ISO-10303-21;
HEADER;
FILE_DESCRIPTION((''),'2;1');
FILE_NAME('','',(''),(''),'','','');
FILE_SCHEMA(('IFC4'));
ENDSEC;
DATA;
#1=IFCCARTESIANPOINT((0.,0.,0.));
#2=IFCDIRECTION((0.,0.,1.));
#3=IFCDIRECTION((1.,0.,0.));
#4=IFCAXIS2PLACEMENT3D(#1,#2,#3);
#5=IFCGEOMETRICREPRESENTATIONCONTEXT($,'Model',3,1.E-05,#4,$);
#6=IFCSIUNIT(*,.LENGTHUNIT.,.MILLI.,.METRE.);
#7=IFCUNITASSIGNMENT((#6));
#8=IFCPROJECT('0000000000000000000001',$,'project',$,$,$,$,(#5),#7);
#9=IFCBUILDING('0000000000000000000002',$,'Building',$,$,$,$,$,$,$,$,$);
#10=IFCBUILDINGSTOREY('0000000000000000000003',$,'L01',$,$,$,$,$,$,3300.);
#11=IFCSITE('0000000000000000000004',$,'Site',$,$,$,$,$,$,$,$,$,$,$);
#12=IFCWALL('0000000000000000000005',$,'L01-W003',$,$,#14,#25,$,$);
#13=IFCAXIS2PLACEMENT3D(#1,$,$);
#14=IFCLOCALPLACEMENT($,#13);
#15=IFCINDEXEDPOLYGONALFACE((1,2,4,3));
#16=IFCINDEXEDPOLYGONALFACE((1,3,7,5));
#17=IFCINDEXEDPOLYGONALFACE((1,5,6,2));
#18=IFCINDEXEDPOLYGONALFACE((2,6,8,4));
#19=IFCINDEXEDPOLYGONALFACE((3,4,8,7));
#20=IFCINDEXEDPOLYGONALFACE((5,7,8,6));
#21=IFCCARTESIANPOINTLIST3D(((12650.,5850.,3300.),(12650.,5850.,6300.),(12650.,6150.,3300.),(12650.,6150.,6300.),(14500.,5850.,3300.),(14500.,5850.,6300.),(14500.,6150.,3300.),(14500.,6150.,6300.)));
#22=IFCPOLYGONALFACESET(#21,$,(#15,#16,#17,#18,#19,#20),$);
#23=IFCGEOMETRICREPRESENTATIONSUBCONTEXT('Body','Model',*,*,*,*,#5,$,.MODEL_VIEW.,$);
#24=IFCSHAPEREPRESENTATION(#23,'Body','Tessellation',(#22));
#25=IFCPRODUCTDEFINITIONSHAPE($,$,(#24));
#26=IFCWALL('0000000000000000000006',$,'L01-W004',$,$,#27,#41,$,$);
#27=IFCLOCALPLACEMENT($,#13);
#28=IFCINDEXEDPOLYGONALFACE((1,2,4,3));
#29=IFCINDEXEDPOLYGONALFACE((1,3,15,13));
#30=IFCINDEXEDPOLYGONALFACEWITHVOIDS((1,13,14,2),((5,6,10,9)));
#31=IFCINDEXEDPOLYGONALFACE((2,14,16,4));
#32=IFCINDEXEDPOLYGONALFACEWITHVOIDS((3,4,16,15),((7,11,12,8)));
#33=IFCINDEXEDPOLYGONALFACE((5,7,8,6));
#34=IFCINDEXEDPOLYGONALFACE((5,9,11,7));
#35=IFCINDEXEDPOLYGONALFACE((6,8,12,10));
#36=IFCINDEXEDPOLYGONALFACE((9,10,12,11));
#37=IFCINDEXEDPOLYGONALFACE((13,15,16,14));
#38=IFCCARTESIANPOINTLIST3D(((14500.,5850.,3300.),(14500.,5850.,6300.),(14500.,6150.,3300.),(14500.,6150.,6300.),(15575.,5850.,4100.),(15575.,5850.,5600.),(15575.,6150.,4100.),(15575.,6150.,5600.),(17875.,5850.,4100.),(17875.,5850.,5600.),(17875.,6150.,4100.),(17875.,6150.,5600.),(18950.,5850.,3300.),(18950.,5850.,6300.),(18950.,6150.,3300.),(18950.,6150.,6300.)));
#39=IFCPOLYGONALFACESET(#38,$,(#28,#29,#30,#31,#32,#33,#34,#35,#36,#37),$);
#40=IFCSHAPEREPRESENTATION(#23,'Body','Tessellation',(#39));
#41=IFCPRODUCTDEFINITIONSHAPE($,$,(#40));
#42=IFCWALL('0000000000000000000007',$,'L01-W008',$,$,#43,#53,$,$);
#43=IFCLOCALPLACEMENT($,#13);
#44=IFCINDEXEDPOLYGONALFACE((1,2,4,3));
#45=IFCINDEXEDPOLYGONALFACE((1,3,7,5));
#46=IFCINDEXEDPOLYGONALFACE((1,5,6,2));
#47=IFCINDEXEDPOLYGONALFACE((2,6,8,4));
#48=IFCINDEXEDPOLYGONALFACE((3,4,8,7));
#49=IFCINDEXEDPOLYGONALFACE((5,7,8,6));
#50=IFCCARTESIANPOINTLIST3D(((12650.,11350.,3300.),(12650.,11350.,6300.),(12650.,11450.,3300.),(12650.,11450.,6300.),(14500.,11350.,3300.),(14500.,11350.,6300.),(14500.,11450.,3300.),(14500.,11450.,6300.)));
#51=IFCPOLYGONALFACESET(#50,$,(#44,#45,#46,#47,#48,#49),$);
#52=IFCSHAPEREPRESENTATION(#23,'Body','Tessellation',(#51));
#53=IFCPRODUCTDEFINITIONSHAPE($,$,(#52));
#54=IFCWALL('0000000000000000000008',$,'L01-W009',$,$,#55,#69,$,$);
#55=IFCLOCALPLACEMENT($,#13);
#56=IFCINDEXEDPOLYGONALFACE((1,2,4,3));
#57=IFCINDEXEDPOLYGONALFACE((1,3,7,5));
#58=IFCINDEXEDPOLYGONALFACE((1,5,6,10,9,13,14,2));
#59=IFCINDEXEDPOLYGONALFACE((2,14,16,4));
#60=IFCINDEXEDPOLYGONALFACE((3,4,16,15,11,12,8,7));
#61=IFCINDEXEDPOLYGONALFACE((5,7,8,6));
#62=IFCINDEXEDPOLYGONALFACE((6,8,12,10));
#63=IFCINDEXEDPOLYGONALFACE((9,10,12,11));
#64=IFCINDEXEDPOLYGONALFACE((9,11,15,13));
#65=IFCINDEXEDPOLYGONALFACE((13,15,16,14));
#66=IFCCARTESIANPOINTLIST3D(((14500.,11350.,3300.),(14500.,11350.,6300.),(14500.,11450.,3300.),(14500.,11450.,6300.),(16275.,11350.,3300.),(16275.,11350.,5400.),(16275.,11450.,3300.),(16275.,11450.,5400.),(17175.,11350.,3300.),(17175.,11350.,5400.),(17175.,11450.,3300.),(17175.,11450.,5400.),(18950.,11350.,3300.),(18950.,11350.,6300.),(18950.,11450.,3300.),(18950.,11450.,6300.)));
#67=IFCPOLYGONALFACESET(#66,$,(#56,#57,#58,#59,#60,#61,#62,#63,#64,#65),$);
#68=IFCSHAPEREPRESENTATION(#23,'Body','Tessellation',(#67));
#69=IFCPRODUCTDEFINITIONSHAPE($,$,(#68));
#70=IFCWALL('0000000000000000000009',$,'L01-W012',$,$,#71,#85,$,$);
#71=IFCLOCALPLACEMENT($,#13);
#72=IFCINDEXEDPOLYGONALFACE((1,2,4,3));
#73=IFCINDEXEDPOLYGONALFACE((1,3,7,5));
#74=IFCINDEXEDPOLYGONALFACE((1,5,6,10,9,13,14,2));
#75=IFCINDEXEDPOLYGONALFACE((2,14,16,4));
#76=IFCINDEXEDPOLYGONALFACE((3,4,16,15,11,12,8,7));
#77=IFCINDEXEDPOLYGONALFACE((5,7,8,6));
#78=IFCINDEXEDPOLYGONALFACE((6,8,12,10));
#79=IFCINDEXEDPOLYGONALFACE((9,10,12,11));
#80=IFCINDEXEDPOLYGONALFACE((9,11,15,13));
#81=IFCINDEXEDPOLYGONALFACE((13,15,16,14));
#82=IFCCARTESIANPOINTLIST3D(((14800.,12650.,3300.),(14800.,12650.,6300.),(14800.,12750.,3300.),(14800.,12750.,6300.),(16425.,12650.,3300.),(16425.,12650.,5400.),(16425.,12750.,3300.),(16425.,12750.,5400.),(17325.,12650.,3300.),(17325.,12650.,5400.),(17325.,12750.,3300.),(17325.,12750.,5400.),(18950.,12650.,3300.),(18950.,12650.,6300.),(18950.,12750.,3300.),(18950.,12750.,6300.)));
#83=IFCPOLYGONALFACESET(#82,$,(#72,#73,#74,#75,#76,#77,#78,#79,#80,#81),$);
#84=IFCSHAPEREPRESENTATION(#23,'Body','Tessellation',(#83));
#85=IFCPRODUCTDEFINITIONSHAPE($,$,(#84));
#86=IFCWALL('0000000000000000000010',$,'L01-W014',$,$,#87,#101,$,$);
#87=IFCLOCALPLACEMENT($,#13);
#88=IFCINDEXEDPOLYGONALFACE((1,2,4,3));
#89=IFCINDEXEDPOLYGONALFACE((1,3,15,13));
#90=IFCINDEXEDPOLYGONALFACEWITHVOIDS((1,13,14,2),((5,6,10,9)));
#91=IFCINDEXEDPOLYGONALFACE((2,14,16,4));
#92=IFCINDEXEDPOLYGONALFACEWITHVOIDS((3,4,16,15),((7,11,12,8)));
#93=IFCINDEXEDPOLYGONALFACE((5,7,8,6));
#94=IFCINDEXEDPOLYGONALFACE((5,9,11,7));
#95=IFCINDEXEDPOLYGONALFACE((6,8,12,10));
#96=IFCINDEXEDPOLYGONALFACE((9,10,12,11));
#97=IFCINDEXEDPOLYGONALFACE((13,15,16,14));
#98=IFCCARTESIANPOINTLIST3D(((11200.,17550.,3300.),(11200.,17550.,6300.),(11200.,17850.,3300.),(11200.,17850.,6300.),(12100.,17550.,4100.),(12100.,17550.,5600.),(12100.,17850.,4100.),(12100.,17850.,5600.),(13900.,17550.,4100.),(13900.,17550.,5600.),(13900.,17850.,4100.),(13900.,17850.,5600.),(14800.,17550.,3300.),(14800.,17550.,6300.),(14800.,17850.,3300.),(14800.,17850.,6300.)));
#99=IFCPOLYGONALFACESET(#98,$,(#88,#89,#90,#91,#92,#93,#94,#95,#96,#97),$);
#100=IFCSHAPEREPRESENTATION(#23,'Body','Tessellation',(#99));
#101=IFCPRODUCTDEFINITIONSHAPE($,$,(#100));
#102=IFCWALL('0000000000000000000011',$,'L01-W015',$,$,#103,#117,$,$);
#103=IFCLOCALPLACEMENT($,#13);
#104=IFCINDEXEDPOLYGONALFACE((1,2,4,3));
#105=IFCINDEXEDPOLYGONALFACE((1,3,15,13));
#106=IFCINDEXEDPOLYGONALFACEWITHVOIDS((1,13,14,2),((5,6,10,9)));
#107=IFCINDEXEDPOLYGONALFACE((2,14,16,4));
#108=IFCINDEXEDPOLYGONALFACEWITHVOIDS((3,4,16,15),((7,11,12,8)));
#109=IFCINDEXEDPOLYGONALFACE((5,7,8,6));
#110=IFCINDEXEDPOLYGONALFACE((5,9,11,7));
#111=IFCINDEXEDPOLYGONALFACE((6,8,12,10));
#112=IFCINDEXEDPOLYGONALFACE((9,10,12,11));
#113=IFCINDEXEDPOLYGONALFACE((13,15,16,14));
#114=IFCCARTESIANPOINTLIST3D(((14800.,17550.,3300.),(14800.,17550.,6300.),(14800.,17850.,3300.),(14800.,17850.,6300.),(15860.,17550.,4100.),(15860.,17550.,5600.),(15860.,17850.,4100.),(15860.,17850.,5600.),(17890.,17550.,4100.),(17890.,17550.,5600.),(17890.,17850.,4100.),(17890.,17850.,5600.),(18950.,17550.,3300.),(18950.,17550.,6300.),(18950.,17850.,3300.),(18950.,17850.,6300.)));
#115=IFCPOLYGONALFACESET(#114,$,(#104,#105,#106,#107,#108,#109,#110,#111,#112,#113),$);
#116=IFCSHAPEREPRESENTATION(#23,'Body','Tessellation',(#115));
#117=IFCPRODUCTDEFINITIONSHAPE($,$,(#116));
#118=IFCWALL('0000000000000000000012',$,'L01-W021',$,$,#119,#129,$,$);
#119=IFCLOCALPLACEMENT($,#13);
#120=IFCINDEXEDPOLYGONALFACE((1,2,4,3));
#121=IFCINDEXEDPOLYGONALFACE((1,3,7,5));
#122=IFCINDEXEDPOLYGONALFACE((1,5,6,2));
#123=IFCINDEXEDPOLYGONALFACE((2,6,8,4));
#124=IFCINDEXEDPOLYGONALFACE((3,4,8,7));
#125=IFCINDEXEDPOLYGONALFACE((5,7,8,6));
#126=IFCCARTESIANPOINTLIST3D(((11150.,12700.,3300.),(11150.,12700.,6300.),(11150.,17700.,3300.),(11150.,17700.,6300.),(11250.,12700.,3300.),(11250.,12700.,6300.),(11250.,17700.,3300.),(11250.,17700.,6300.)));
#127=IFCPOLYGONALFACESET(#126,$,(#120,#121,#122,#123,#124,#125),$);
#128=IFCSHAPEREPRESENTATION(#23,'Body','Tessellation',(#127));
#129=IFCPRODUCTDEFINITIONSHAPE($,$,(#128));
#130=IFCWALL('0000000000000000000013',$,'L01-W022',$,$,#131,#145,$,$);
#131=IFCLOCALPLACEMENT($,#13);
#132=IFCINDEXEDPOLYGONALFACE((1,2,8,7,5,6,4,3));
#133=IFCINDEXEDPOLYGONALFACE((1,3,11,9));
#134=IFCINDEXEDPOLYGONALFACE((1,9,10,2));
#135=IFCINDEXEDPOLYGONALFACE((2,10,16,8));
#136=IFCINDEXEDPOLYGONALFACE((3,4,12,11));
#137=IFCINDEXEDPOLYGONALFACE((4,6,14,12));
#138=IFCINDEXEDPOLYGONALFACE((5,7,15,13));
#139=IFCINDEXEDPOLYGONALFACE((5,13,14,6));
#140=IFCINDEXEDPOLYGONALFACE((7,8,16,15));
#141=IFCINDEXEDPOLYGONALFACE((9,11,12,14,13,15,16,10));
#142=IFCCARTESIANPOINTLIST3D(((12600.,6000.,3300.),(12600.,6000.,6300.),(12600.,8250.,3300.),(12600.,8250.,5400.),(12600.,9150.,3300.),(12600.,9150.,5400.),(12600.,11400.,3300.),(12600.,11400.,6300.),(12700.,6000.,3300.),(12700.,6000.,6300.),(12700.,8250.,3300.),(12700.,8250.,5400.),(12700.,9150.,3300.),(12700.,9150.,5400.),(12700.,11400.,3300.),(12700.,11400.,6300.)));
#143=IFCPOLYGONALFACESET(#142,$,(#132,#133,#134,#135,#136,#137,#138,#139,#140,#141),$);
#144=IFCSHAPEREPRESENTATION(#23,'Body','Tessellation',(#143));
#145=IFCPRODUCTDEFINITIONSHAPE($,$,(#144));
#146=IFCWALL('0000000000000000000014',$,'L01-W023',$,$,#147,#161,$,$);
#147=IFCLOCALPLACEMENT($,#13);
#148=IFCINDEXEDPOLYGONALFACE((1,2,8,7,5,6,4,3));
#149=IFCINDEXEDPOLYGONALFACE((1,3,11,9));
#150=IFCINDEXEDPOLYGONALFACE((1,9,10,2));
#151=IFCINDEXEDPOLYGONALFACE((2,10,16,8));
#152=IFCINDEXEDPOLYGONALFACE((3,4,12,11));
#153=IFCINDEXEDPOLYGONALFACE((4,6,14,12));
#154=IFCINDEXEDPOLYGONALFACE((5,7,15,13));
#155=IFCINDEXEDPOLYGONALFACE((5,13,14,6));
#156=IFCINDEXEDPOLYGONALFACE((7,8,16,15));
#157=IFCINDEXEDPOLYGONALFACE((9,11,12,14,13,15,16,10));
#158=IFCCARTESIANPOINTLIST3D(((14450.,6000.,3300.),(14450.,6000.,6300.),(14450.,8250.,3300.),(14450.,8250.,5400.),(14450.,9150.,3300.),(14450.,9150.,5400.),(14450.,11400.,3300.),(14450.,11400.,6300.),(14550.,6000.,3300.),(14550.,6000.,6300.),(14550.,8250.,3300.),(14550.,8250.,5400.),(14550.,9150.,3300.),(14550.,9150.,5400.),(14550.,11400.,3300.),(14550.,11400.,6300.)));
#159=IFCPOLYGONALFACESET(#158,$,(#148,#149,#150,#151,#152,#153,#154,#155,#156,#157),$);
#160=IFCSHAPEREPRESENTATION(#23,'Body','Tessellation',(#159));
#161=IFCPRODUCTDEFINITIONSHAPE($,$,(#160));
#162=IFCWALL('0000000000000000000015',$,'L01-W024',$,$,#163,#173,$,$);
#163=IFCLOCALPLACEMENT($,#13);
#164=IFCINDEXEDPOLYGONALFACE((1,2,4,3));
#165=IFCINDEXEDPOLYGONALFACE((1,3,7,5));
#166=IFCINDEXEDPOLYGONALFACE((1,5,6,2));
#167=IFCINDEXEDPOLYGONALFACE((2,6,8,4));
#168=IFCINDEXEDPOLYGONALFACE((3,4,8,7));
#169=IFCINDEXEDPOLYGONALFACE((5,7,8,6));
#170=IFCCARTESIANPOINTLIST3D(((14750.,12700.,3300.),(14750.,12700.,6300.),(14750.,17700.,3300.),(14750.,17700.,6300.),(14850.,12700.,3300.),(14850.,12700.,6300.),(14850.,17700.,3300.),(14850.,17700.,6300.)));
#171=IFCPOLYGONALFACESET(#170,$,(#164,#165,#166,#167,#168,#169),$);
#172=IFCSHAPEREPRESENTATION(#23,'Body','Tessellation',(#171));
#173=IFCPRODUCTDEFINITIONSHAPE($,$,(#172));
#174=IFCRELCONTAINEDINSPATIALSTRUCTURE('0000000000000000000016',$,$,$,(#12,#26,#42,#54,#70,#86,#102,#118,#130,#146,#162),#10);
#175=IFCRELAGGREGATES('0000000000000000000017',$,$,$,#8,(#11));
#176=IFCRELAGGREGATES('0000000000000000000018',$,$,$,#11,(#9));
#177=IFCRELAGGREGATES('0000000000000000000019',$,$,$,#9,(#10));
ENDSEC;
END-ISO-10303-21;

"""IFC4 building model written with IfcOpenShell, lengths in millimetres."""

from ifc_helpers import new_model, si_unit, frame, origin_with_axes, place, context, subcontext, project, spatial, indexed_curve, outline, extrude, element, save


model = new_model("IFC4")

# Units and contexts
model_context = context("Model", 3, precision=1e-05, world=origin_with_axes())
body_context = subcontext(model_context, "Body", "Model", "MODEL_VIEW")
ifc_project = project(units=[si_unit("LENGTHUNIT", "METRE", prefix="MILLI")], contexts=[model_context])

# Site, building, storey
site = spatial("IfcSite", under=ifc_project, Name="Site")
building = spatial("IfcBuilding", under=site, Name="Building")
storey = spatial("IfcBuildingStorey", under=building, Name="L01", Elevation=3300.0)

# Wall
wall_1_placement = place(None, frame((12650.0, 5850.0, 3300.0), z_axis=(0.0, 0.0, 1.0), x_axis=(1.0, 0.0, 0.0)))
element("IfcWall", 1, at=wall_1_placement, inside=storey, Name="L01-W003", context=body_context, shape_type="SweptSolid", body=[
    extrude(outline(indexed_curve([(0.0, 0.0), (0.0, 300.0), (1850.0, 300.0), (1850.0, 0.0), (0.0, 0.0)], self_intersect=False)), origin_with_axes(), (0.0, 0.0, 1.0), 3000.0),
])

# Wall, opening
wall_2_placement = place(None, frame((14500.0, 5850.0, 3300.0), z_axis=(0.0, 0.0, 1.0), x_axis=(1.0, 0.0, 0.0)))
wall_2 = element("IfcWall", 2, at=wall_2_placement, inside=storey, Name="L01-W004", context=body_context, shape_type="SweptSolid", body=[
    extrude(outline(indexed_curve([(0.0, 0.0), (0.0, 300.0), (4450.0, 300.0), (4450.0, 0.0), (0.0, 0.0)], self_intersect=False)), origin_with_axes(), (0.0, 0.0, 1.0), 3000.0),
])
opening_1_placement = place(wall_2_placement, frame((1075.0, -10.0, 800.0), z_axis=(0.0, 0.0, 1.0), x_axis=(1.0, 0.0, 0.0)))
element("IfcOpeningElement", 3, at=opening_1_placement, cuts=wall_2, context=body_context, shape_type="SweptSolid", body=[
    extrude(outline(indexed_curve([(0.0, 0.0), (0.0, 320.0), (2300.0, 320.0), (2300.0, 0.0), (0.0, 0.0)], self_intersect=False)), origin_with_axes(), (0.0, 0.0, 1.0), 1500.0),
])

# Wall
wall_3_placement = place(None, frame((12650.0, 11350.0, 3300.0), z_axis=(0.0, 0.0, 1.0), x_axis=(1.0, 0.0, 0.0)))
element("IfcWall", 4, at=wall_3_placement, inside=storey, Name="L01-W008", context=body_context, shape_type="SweptSolid", body=[
    extrude(outline(indexed_curve([(0.0, 0.0), (0.0, 100.0), (1850.0, 100.0), (1850.0, 0.0), (0.0, 0.0)], self_intersect=False)), origin_with_axes(), (0.0, 0.0, 1.0), 3000.0),
])

# Walls, openings
wall_4_placement = place(None, frame((14500.0, 11350.0, 3300.0), z_axis=(0.0, 0.0, 1.0), x_axis=(1.0, 0.0, 0.0)))
wall_4 = element("IfcWall", 5, at=wall_4_placement, inside=storey, Name="L01-W009", context=body_context, shape_type="SweptSolid", body=[
    extrude(outline(indexed_curve([(0.0, 0.0), (0.0, 100.0), (4450.0, 100.0), (4450.0, 0.0), (0.0, 0.0)], self_intersect=False)), origin_with_axes(), (0.0, 0.0, 1.0), 3000.0),
])
opening_2_placement = place(wall_4_placement, frame((1775.0, -10.0, 0.0), z_axis=(0.0, 0.0, 1.0), x_axis=(1.0, 0.0, 0.0)))
element("IfcOpeningElement", 6, at=opening_2_placement, cuts=wall_4, context=body_context, shape_type="SweptSolid", body=[
    extrude(outline(indexed_curve([(0.0, 0.0), (0.0, 120.0), (900.0, 120.0), (900.0, 0.0), (0.0, 0.0)], self_intersect=False)), origin_with_axes(), (0.0, 0.0, 1.0), 2100.0),
])
wall_5_placement = place(None, frame((14800.0, 12650.0, 3300.0), z_axis=(0.0, 0.0, 1.0), x_axis=(1.0, 0.0, 0.0)))
wall_5 = element("IfcWall", 7, at=wall_5_placement, inside=storey, Name="L01-W012", context=body_context, shape_type="SweptSolid", body=[
    extrude(outline(indexed_curve([(0.0, 0.0), (0.0, 100.0), (4150.0, 100.0), (4150.0, 0.0), (0.0, 0.0)], self_intersect=False)), origin_with_axes(), (0.0, 0.0, 1.0), 3000.0),
])
opening_3_placement = place(wall_5_placement, frame((1625.0, -10.0, 0.0), z_axis=(0.0, 0.0, 1.0), x_axis=(1.0, 0.0, 0.0)))
element("IfcOpeningElement", 8, at=opening_3_placement, cuts=wall_5, context=body_context, shape_type="SweptSolid", body=[
    extrude(outline(indexed_curve([(0.0, 0.0), (0.0, 120.0), (900.0, 120.0), (900.0, 0.0), (0.0, 0.0)], self_intersect=False)), origin_with_axes(), (0.0, 0.0, 1.0), 2100.0),
])
wall_6_placement = place(None, frame((11200.0, 17550.0, 3300.0), z_axis=(0.0, 0.0, 1.0), x_axis=(1.0, 0.0, 0.0)))
wall_6 = element("IfcWall", 9, at=wall_6_placement, inside=storey, Name="L01-W014", context=body_context, shape_type="SweptSolid", body=[
    extrude(outline(indexed_curve([(0.0, 0.0), (0.0, 300.0), (3600.0, 300.0), (3600.0, 0.0), (0.0, 0.0)], self_intersect=False)), origin_with_axes(), (0.0, 0.0, 1.0), 3000.0),
])
opening_4_placement = place(wall_6_placement, frame((900.0, -10.0, 800.0), z_axis=(0.0, 0.0, 1.0), x_axis=(1.0, 0.0, 0.0)))
element("IfcOpeningElement", 10, at=opening_4_placement, cuts=wall_6, context=body_context, shape_type="SweptSolid", body=[
    extrude(outline(indexed_curve([(0.0, 0.0), (0.0, 320.0), (1800.0, 320.0), (1800.0, 0.0), (0.0, 0.0)], self_intersect=False)), origin_with_axes(), (0.0, 0.0, 1.0), 1500.0),
])
wall_7_placement = place(None, frame((14800.0, 17550.0, 3300.0), z_axis=(0.0, 0.0, 1.0), x_axis=(1.0, 0.0, 0.0)))
wall_7 = element("IfcWall", 11, at=wall_7_placement, inside=storey, Name="L01-W015", context=body_context, shape_type="SweptSolid", body=[
    extrude(outline(indexed_curve([(0.0, 0.0), (0.0, 300.0), (4150.0, 300.0), (4150.0, 0.0), (0.0, 0.0)], self_intersect=False)), origin_with_axes(), (0.0, 0.0, 1.0), 3000.0),
])
opening_5_placement = place(wall_7_placement, frame((1060.0, -10.0, 800.0), z_axis=(0.0, 0.0, 1.0), x_axis=(1.0, 0.0, 0.0)))
element("IfcOpeningElement", 12, at=opening_5_placement, cuts=wall_7, context=body_context, shape_type="SweptSolid", body=[
    extrude(outline(indexed_curve([(0.0, 0.0), (0.0, 320.0), (2030.0, 320.0), (2030.0, 0.0), (0.0, 0.0)], self_intersect=False)), origin_with_axes(), (0.0, 0.0, 1.0), 1500.0),
])

# Wall
wall_8_placement = place(None, frame((11250.0, 12700.0, 3300.0), z_axis=(0.0, 0.0, 1.0), x_axis=(0.0, 1.0, 0.0)))
element("IfcWall", 13, at=wall_8_placement, inside=storey, Name="L01-W021", context=body_context, shape_type="SweptSolid", body=[
    extrude(outline(indexed_curve([(0.0, 0.0), (0.0, 100.0), (5000.0, 100.0), (5000.0, 0.0), (0.0, 0.0)], self_intersect=False)), origin_with_axes(), (0.0, 0.0, 1.0), 3000.0),
])

# Walls, openings
wall_9_placement = place(None, frame((12700.0, 6000.0, 3300.0), z_axis=(0.0, 0.0, 1.0), x_axis=(0.0, 1.0, 0.0)))
wall_9 = element("IfcWall", 14, at=wall_9_placement, inside=storey, Name="L01-W022", context=body_context, shape_type="SweptSolid", body=[
    extrude(outline(indexed_curve([(0.0, 0.0), (0.0, 100.0), (5400.0, 100.0), (5400.0, 0.0), (0.0, 0.0)], self_intersect=False)), origin_with_axes(), (0.0, 0.0, 1.0), 3000.0),
])
opening_6_placement = place(wall_9_placement, frame((2250.0, -10.0, 0.0), z_axis=(0.0, 0.0, 1.0), x_axis=(1.0, 0.0, 0.0)))
element("IfcOpeningElement", 15, at=opening_6_placement, cuts=wall_9, context=body_context, shape_type="SweptSolid", body=[
    extrude(outline(indexed_curve([(0.0, 0.0), (0.0, 120.0), (900.0, 120.0), (900.0, 0.0), (0.0, 0.0)], self_intersect=False)), origin_with_axes(), (0.0, 0.0, 1.0), 2100.0),
])
wall_10_placement = place(None, frame((14550.0, 6000.0, 3300.0), z_axis=(0.0, 0.0, 1.0), x_axis=(0.0, 1.0, 0.0)))
wall_10 = element("IfcWall", 16, at=wall_10_placement, inside=storey, Name="L01-W023", context=body_context, shape_type="SweptSolid", body=[
    extrude(outline(indexed_curve([(0.0, 0.0), (0.0, 100.0), (5400.0, 100.0), (5400.0, 0.0), (0.0, 0.0)], self_intersect=False)), origin_with_axes(), (0.0, 0.0, 1.0), 3000.0),
])
opening_7_placement = place(wall_10_placement, frame((2250.0, -10.0, 0.0), z_axis=(0.0, 0.0, 1.0), x_axis=(1.0, 0.0, 0.0)))
element("IfcOpeningElement", 17, at=opening_7_placement, cuts=wall_10, context=body_context, shape_type="SweptSolid", body=[
    extrude(outline(indexed_curve([(0.0, 0.0), (0.0, 120.0), (900.0, 120.0), (900.0, 0.0), (0.0, 0.0)], self_intersect=False)), origin_with_axes(), (0.0, 0.0, 1.0), 2100.0),
])

# Wall
wall_11_placement = place(None, frame((14850.0, 12700.0, 3300.0), z_axis=(0.0, 0.0, 1.0), x_axis=(0.0, 1.0, 0.0)))
element("IfcWall", 18, at=wall_11_placement, inside=storey, Name="L01-W024", context=body_context, shape_type="SweptSolid", body=[
    extrude(outline(indexed_curve([(0.0, 0.0), (0.0, 100.0), (5000.0, 100.0), (5000.0, 0.0), (0.0, 0.0)], self_intersect=False)), origin_with_axes(), (0.0, 0.0, 1.0), 3000.0),
])

save(model, "model.ifc")
